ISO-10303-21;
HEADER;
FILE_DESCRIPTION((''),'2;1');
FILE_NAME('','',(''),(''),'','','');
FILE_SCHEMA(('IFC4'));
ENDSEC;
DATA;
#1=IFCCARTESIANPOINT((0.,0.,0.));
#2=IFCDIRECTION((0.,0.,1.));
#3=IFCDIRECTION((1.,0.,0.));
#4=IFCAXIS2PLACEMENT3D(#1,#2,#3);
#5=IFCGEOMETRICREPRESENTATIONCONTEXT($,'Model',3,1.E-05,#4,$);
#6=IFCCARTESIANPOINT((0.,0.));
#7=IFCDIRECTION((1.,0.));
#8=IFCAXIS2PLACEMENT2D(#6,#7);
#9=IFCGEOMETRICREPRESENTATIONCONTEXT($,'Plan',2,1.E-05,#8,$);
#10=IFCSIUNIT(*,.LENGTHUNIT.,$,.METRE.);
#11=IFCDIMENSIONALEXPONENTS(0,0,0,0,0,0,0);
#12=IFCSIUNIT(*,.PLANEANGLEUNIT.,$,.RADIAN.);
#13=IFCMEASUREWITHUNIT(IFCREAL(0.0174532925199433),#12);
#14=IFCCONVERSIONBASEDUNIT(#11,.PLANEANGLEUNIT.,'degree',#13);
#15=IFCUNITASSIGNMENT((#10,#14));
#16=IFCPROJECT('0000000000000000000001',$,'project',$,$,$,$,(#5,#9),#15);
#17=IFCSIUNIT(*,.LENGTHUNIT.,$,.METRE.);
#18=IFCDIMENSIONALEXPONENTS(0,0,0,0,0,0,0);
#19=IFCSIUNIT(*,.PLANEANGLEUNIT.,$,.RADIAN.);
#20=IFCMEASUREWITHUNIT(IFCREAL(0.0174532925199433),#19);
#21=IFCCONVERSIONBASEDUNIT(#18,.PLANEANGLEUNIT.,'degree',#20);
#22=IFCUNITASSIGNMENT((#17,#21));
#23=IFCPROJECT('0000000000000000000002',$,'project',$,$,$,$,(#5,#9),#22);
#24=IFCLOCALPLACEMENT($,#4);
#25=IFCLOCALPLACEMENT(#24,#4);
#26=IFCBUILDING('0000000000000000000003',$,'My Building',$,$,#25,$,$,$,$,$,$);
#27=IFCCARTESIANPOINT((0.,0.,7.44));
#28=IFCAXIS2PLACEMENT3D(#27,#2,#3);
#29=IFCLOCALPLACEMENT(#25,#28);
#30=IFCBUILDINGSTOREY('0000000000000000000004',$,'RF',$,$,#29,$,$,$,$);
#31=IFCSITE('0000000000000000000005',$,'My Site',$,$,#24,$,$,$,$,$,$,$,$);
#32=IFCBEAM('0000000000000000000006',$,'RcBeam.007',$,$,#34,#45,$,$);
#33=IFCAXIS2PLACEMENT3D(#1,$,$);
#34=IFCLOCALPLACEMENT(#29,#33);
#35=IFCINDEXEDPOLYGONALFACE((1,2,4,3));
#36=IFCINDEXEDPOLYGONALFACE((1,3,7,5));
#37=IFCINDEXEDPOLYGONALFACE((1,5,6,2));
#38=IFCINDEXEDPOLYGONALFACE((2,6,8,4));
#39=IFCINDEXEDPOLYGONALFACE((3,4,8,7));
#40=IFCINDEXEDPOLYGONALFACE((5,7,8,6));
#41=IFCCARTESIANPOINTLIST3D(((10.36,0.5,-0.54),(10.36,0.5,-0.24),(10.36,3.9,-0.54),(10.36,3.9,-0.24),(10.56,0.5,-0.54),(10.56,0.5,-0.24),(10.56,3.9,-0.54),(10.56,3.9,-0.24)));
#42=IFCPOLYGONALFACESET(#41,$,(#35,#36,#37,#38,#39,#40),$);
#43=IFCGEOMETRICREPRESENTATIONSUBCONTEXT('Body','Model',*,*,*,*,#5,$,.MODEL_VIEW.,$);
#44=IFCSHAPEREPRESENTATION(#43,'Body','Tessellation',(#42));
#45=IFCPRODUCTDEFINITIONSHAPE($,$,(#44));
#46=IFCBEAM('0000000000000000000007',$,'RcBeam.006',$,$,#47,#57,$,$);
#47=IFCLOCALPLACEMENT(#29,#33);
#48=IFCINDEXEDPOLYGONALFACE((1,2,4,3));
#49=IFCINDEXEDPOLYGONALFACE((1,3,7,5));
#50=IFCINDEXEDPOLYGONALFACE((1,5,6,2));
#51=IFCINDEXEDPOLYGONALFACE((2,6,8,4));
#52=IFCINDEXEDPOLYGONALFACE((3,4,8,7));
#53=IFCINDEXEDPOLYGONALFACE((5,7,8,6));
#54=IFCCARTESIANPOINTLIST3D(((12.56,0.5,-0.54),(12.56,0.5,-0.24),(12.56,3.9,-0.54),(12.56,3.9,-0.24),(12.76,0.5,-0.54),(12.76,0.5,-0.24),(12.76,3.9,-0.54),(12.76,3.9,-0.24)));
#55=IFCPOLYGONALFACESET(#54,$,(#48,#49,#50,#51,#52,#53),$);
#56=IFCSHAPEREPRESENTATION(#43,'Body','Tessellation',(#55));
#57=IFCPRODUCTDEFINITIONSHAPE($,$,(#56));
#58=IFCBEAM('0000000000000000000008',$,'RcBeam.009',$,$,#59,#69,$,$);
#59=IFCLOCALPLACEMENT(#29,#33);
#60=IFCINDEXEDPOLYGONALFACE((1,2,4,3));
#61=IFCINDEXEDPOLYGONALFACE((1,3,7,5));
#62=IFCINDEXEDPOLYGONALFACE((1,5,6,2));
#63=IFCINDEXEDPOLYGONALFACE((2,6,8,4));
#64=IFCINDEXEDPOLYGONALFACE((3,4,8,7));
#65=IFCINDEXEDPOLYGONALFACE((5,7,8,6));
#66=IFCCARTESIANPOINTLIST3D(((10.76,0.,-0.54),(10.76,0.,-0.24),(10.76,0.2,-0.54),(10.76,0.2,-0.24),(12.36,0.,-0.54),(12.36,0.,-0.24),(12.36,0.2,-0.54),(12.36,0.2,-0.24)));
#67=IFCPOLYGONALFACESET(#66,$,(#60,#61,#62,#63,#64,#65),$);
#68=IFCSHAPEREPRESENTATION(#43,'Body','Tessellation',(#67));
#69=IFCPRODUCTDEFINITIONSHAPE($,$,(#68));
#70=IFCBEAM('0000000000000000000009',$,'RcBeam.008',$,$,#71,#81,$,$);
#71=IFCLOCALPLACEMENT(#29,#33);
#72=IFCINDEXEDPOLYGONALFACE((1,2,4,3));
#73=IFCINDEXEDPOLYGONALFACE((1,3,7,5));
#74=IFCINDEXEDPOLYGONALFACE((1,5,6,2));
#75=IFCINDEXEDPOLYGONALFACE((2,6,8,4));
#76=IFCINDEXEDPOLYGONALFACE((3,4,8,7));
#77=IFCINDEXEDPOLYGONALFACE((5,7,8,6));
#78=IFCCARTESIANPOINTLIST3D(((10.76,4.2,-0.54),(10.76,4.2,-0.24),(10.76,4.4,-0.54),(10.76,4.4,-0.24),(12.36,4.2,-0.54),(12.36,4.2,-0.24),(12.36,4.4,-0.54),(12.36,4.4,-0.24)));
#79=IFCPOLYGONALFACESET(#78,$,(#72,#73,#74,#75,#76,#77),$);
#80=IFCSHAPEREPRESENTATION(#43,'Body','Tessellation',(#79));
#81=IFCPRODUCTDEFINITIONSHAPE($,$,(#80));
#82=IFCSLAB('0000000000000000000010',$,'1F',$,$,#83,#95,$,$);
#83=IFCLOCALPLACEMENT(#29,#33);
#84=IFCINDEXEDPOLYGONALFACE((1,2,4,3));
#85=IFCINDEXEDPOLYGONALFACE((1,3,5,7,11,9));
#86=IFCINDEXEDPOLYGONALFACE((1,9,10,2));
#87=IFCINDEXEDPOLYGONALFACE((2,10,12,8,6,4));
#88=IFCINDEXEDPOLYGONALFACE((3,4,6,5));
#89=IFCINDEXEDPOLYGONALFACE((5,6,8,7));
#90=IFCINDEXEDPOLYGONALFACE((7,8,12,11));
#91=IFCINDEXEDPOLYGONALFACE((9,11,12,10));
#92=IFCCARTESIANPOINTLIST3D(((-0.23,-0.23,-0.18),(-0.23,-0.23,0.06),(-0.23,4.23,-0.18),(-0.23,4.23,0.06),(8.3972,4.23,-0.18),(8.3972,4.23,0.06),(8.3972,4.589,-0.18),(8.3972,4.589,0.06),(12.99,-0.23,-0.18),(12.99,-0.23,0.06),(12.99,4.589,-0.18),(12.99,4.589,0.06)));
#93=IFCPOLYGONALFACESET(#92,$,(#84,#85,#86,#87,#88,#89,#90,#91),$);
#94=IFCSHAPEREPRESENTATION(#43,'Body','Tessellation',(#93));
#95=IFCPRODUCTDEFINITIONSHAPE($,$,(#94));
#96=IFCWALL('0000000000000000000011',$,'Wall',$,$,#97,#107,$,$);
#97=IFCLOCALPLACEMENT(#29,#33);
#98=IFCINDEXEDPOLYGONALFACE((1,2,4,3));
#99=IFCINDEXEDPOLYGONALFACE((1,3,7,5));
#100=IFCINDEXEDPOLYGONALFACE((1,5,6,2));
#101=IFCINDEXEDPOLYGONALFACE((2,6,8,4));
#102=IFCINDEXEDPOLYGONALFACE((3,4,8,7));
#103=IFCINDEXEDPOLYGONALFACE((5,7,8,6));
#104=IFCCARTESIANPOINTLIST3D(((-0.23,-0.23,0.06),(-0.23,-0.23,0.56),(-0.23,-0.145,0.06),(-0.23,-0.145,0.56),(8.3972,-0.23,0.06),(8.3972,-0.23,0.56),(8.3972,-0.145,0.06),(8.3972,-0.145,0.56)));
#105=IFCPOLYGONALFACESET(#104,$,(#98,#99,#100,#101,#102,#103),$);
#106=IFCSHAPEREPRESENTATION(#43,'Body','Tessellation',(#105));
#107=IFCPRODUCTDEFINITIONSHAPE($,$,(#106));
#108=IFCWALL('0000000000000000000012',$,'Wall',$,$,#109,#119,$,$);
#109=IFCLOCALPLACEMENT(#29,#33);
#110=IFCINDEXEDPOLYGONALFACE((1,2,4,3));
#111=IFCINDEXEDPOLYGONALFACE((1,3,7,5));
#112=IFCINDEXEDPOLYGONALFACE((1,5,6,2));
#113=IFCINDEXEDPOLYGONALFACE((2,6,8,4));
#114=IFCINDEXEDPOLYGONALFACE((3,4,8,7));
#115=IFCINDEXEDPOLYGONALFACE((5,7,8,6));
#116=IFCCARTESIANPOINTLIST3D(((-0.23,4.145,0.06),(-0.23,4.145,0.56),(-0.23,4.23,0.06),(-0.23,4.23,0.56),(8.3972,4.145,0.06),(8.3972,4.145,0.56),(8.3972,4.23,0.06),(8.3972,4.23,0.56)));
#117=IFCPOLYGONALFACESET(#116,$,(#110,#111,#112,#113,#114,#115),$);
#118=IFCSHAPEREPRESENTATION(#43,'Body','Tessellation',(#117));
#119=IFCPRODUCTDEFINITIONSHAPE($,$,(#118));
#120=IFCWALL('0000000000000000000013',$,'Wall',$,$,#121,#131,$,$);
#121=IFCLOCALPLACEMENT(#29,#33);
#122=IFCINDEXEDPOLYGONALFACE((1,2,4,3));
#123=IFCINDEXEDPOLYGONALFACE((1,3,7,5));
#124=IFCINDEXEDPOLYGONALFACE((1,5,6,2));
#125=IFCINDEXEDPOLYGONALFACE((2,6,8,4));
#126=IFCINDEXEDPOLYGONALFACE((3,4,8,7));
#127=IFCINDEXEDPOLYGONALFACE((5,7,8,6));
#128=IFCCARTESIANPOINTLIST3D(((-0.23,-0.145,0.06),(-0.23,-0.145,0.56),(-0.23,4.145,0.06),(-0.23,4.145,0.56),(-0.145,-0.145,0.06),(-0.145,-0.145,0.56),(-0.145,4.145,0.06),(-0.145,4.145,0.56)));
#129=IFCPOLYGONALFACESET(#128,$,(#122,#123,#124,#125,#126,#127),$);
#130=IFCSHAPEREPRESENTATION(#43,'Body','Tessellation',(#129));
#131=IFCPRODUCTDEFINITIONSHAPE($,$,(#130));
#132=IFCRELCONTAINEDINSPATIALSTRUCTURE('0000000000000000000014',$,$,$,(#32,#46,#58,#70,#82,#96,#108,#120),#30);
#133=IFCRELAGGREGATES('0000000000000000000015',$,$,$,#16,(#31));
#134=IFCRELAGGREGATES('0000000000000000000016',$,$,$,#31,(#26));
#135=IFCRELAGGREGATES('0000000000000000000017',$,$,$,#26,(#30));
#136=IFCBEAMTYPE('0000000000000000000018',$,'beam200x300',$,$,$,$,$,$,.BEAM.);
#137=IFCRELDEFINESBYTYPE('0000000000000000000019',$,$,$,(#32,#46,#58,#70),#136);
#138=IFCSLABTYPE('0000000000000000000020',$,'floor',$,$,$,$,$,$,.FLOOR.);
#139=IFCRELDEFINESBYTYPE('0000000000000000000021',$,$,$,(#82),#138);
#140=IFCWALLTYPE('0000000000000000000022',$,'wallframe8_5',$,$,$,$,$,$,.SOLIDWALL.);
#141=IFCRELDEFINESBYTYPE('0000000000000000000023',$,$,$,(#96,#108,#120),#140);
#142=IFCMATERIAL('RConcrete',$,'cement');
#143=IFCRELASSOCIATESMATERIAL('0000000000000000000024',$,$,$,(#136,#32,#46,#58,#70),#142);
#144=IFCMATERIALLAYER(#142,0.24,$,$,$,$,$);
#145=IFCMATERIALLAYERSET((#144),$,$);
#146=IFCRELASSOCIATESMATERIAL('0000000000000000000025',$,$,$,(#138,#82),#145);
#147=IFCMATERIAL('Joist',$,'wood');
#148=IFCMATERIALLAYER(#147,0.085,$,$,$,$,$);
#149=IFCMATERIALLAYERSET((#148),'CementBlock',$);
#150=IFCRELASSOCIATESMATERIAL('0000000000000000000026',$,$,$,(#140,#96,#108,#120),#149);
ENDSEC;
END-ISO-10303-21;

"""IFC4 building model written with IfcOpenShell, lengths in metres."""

from ifc_helpers import new_model, entity, si_unit, converted_unit, frame, origin_with_axes, origin_2d_with_axis, place, context, subcontext, project, spatial, line, indexed_curve, rectangle, outline, extrude, material, layer, layer_set, layer_usage, material_profile, profile_set, profile_usage, type_object, element, save


model = new_model("IFC4")

# Units and contexts
model_context = context("Model", 3, precision=1e-05, world=origin_with_axes())
plan_context = context("Plan", 2, precision=1e-05, world=origin_2d_with_axis())
body_context = subcontext(model_context, "Body", "Model", "MODEL_VIEW")
ifc_project_1 = project(units=[si_unit("LENGTHUNIT", "METRE"), converted_unit("PLANEANGLEUNIT", "degree", entity("IfcReal", 0.0174532925199433), si_unit("PLANEANGLEUNIT", "RADIAN"), dimensions=[0, 0, 0, 0, 0, 0, 0])], contexts=[model_context, plan_context])
ifc_project_2 = project(units=[si_unit("LENGTHUNIT", "METRE"), converted_unit("PLANEANGLEUNIT", "degree", entity("IfcReal", 0.0174532925199433), si_unit("PLANEANGLEUNIT", "RADIAN"), dimensions=[0, 0, 0, 0, 0, 0, 0])], contexts=[model_context, plan_context])

# Site, building, storey
site_placement = place(None, origin_with_axes())
site = spatial("IfcSite", under=ifc_project_1, at=site_placement, Name="My Site")
building_placement = place(site_placement, origin_with_axes())
building = spatial("IfcBuilding", under=site, at=building_placement, Name="My Building")
storey_placement = place(building_placement, frame((0.0, 0.0, 7.44), z_axis=(0.0, 0.0, 1.0), x_axis=(1.0, 0.0, 0.0)))
storey = spatial("IfcBuildingStorey", under=building, at=storey_placement, Name="RF")

# Beams
ifc_material_1 = material(Name="RConcrete", Category="cement")
ifc_material_profile = material_profile(ifc_material_1, rectangle(XDim=0.2, YDim=0.3))
ifc_profile_set = profile_set([ifc_material_profile], Name="RConcrete")
ifc_profile_usage_1 = profile_usage(ifc_profile_set, cardinal=1)
beam_type = type_object("IfcBeamType", Name="beam200x300", PredefinedType="BEAM", material=ifc_profile_set)
beam_1_placement = place(storey_placement, frame((10.56, 3.9, -0.54), z_axis=(0.0, -1.0, 0.0), x_axis=(1.0, 0.0, 0.0)))
element("IfcBeam", 1, at=beam_1_placement, inside=storey, type_object=beam_type, material=ifc_profile_usage_1, Name="RcBeam.007", context=body_context, shape_type="SweptSolid", body=[
    extrude(rectangle(XDim=0.2, YDim=0.3), frame((-0.1, 0.15, 0.0), z_axis=(0.0, 0.0, 1.0), x_axis=(1.0, 0.0, 0.0)), (0.0, 0.0, 1.0), 3.4),
])
ifc_profile_usage_2 = profile_usage(ifc_profile_set, cardinal=1)
beam_2_placement = place(storey_placement, frame((12.76, 3.9, -0.54), z_axis=(0.0, -1.0, 0.0), x_axis=(1.0, 0.0, 0.0)))
element("IfcBeam", 2, at=beam_2_placement, inside=storey, type_object=beam_type, material=ifc_profile_usage_2, Name="RcBeam.006", context=body_context, shape_type="SweptSolid", body=[
    extrude(rectangle(XDim=0.2, YDim=0.3), frame((-0.1, 0.15, 0.0), z_axis=(0.0, 0.0, 1.0), x_axis=(1.0, 0.0, 0.0)), (0.0, 0.0, 1.0), 3.4),
])
ifc_profile_usage_3 = profile_usage(ifc_profile_set, cardinal=1)
beam_3_placement = place(storey_placement, frame((10.76, 0.2, -0.54), z_axis=(1.0, 0.0, 0.0), x_axis=(0.0, 1.0, 0.0)))
element("IfcBeam", 3, at=beam_3_placement, inside=storey, type_object=beam_type, material=ifc_profile_usage_3, Name="RcBeam.009", context=body_context, shape_type="SweptSolid", body=[
    extrude(rectangle(XDim=0.2, YDim=0.3), frame((-0.1, 0.15, 0.0), z_axis=(0.0, 0.0, 1.0), x_axis=(1.0, 0.0, 0.0)), (0.0, 0.0, 1.0), 1.6),
])
ifc_profile_usage_4 = profile_usage(ifc_profile_set, cardinal=1)
beam_4_placement = place(storey_placement, frame((10.76, 4.4, -0.54), z_axis=(1.0, 0.0, 0.0), x_axis=(0.0, 1.0, 0.0)))
element("IfcBeam", 4, at=beam_4_placement, inside=storey, type_object=beam_type, material=ifc_profile_usage_4, Name="RcBeam.008", context=body_context, shape_type="SweptSolid", body=[
    extrude(rectangle(XDim=0.2, YDim=0.3), frame((-0.1, 0.15, 0.0), z_axis=(0.0, 0.0, 1.0), x_axis=(1.0, 0.0, 0.0)), (0.0, 0.0, 1.0), 1.6),
])

# Slab
ifc_layer_1 = layer(ifc_material_1, 0.24)
ifc_layer_set_1 = layer_set([ifc_layer_1])
ifc_layer_usage_1 = layer_usage(ifc_layer_set_1, "AXIS3", "POSITIVE", 0.0)
slab_type = type_object("IfcSlabType", Name="floor", PredefinedType="FLOOR", material=ifc_layer_set_1)
slab_placement = place(storey_placement, frame((0.0, 0.0, -0.18), z_axis=(0.0, 0.0, 1.0), x_axis=(1.0, 0.0, 0.0)))
element("IfcSlab", 5, at=slab_placement, inside=storey, type_object=slab_type, material=ifc_layer_usage_1, Name="1F", context=body_context, shape_type="SweptSolid", body=[
    extrude(outline(indexed_curve([(-0.23, -0.23), (-0.23, 4.23), (8.3972, 4.23), (8.3972, 4.589), (12.99, 4.589), (12.99, -0.23)], segments=[line(1, 6), line(6, 5), line(5, 4), line(4, 3), line(3, 2), line(2, 1)], self_intersect=False)), None, (0.0, 0.0, 1.0), 0.24),
])

# Walls
ifc_material_2 = material(Name="Joist", Category="wood")
ifc_layer_2 = layer(ifc_material_2, 0.085)
ifc_layer_set_2 = layer_set([ifc_layer_2], Name="CementBlock")
ifc_layer_usage_2 = layer_usage(ifc_layer_set_2, "AXIS2", "POSITIVE", 0.0)
wall_type = type_object("IfcWallType", Name="wallframe8_5", PredefinedType="SOLIDWALL", material=ifc_layer_set_2)
wall_1_placement = place(storey_placement, frame((-0.23, -0.23, 0.06), z_axis=(0.0, 0.0, 1.0), x_axis=(1.0, 0.0, 0.0)))
element("IfcWall", 6, at=wall_1_placement, inside=storey, type_object=wall_type, material=ifc_layer_usage_2, Name="Wall", context=body_context, shape_type="SweptSolid", body=[
    extrude(outline(indexed_curve([(0.0, 0.0), (0.0, 0.085), (8.6272, 0.085), (8.6272, 0.0), (0.0, 0.0)], self_intersect=False)), origin_with_axes(), (0.0, 0.0, 1.0), 0.5),
])
ifc_layer_usage_3 = layer_usage(ifc_layer_set_2, "AXIS2", "POSITIVE", 0.0)
wall_2_placement = place(storey_placement, frame((8.3972, 4.23, 0.06), z_axis=(0.0, 0.0, 1.0), x_axis=(-1.0, 0.0, 0.0)))
element("IfcWall", 7, at=wall_2_placement, inside=storey, type_object=wall_type, material=ifc_layer_usage_3, Name="Wall", context=body_context, shape_type="SweptSolid", body=[
    extrude(outline(indexed_curve([(0.0, 0.0), (0.0, 0.085), (8.6272, 0.085), (8.6272, 0.0), (0.0, 0.0)], self_intersect=False)), origin_with_axes(), (0.0, 0.0, 1.0), 0.5),
])
ifc_layer_usage_4 = layer_usage(ifc_layer_set_2, "AXIS2", "POSITIVE", 0.0)
wall_3_placement = place(storey_placement, frame((-0.23, 4.145, 0.06), z_axis=(0.0, 0.0, 1.0), x_axis=(0.0, -1.0, 0.0)))
element("IfcWall", 8, at=wall_3_placement, inside=storey, type_object=wall_type, material=ifc_layer_usage_4, Name="Wall", context=body_context, shape_type="SweptSolid", body=[
    extrude(outline(indexed_curve([(0.0, 0.0), (0.0, 0.085), (4.29, 0.085), (4.29, 0.0), (0.0, 0.0)], self_intersect=False)), origin_with_axes(), (0.0, 0.0, 1.0), 0.5),
])

save(model, "model.ifc")
